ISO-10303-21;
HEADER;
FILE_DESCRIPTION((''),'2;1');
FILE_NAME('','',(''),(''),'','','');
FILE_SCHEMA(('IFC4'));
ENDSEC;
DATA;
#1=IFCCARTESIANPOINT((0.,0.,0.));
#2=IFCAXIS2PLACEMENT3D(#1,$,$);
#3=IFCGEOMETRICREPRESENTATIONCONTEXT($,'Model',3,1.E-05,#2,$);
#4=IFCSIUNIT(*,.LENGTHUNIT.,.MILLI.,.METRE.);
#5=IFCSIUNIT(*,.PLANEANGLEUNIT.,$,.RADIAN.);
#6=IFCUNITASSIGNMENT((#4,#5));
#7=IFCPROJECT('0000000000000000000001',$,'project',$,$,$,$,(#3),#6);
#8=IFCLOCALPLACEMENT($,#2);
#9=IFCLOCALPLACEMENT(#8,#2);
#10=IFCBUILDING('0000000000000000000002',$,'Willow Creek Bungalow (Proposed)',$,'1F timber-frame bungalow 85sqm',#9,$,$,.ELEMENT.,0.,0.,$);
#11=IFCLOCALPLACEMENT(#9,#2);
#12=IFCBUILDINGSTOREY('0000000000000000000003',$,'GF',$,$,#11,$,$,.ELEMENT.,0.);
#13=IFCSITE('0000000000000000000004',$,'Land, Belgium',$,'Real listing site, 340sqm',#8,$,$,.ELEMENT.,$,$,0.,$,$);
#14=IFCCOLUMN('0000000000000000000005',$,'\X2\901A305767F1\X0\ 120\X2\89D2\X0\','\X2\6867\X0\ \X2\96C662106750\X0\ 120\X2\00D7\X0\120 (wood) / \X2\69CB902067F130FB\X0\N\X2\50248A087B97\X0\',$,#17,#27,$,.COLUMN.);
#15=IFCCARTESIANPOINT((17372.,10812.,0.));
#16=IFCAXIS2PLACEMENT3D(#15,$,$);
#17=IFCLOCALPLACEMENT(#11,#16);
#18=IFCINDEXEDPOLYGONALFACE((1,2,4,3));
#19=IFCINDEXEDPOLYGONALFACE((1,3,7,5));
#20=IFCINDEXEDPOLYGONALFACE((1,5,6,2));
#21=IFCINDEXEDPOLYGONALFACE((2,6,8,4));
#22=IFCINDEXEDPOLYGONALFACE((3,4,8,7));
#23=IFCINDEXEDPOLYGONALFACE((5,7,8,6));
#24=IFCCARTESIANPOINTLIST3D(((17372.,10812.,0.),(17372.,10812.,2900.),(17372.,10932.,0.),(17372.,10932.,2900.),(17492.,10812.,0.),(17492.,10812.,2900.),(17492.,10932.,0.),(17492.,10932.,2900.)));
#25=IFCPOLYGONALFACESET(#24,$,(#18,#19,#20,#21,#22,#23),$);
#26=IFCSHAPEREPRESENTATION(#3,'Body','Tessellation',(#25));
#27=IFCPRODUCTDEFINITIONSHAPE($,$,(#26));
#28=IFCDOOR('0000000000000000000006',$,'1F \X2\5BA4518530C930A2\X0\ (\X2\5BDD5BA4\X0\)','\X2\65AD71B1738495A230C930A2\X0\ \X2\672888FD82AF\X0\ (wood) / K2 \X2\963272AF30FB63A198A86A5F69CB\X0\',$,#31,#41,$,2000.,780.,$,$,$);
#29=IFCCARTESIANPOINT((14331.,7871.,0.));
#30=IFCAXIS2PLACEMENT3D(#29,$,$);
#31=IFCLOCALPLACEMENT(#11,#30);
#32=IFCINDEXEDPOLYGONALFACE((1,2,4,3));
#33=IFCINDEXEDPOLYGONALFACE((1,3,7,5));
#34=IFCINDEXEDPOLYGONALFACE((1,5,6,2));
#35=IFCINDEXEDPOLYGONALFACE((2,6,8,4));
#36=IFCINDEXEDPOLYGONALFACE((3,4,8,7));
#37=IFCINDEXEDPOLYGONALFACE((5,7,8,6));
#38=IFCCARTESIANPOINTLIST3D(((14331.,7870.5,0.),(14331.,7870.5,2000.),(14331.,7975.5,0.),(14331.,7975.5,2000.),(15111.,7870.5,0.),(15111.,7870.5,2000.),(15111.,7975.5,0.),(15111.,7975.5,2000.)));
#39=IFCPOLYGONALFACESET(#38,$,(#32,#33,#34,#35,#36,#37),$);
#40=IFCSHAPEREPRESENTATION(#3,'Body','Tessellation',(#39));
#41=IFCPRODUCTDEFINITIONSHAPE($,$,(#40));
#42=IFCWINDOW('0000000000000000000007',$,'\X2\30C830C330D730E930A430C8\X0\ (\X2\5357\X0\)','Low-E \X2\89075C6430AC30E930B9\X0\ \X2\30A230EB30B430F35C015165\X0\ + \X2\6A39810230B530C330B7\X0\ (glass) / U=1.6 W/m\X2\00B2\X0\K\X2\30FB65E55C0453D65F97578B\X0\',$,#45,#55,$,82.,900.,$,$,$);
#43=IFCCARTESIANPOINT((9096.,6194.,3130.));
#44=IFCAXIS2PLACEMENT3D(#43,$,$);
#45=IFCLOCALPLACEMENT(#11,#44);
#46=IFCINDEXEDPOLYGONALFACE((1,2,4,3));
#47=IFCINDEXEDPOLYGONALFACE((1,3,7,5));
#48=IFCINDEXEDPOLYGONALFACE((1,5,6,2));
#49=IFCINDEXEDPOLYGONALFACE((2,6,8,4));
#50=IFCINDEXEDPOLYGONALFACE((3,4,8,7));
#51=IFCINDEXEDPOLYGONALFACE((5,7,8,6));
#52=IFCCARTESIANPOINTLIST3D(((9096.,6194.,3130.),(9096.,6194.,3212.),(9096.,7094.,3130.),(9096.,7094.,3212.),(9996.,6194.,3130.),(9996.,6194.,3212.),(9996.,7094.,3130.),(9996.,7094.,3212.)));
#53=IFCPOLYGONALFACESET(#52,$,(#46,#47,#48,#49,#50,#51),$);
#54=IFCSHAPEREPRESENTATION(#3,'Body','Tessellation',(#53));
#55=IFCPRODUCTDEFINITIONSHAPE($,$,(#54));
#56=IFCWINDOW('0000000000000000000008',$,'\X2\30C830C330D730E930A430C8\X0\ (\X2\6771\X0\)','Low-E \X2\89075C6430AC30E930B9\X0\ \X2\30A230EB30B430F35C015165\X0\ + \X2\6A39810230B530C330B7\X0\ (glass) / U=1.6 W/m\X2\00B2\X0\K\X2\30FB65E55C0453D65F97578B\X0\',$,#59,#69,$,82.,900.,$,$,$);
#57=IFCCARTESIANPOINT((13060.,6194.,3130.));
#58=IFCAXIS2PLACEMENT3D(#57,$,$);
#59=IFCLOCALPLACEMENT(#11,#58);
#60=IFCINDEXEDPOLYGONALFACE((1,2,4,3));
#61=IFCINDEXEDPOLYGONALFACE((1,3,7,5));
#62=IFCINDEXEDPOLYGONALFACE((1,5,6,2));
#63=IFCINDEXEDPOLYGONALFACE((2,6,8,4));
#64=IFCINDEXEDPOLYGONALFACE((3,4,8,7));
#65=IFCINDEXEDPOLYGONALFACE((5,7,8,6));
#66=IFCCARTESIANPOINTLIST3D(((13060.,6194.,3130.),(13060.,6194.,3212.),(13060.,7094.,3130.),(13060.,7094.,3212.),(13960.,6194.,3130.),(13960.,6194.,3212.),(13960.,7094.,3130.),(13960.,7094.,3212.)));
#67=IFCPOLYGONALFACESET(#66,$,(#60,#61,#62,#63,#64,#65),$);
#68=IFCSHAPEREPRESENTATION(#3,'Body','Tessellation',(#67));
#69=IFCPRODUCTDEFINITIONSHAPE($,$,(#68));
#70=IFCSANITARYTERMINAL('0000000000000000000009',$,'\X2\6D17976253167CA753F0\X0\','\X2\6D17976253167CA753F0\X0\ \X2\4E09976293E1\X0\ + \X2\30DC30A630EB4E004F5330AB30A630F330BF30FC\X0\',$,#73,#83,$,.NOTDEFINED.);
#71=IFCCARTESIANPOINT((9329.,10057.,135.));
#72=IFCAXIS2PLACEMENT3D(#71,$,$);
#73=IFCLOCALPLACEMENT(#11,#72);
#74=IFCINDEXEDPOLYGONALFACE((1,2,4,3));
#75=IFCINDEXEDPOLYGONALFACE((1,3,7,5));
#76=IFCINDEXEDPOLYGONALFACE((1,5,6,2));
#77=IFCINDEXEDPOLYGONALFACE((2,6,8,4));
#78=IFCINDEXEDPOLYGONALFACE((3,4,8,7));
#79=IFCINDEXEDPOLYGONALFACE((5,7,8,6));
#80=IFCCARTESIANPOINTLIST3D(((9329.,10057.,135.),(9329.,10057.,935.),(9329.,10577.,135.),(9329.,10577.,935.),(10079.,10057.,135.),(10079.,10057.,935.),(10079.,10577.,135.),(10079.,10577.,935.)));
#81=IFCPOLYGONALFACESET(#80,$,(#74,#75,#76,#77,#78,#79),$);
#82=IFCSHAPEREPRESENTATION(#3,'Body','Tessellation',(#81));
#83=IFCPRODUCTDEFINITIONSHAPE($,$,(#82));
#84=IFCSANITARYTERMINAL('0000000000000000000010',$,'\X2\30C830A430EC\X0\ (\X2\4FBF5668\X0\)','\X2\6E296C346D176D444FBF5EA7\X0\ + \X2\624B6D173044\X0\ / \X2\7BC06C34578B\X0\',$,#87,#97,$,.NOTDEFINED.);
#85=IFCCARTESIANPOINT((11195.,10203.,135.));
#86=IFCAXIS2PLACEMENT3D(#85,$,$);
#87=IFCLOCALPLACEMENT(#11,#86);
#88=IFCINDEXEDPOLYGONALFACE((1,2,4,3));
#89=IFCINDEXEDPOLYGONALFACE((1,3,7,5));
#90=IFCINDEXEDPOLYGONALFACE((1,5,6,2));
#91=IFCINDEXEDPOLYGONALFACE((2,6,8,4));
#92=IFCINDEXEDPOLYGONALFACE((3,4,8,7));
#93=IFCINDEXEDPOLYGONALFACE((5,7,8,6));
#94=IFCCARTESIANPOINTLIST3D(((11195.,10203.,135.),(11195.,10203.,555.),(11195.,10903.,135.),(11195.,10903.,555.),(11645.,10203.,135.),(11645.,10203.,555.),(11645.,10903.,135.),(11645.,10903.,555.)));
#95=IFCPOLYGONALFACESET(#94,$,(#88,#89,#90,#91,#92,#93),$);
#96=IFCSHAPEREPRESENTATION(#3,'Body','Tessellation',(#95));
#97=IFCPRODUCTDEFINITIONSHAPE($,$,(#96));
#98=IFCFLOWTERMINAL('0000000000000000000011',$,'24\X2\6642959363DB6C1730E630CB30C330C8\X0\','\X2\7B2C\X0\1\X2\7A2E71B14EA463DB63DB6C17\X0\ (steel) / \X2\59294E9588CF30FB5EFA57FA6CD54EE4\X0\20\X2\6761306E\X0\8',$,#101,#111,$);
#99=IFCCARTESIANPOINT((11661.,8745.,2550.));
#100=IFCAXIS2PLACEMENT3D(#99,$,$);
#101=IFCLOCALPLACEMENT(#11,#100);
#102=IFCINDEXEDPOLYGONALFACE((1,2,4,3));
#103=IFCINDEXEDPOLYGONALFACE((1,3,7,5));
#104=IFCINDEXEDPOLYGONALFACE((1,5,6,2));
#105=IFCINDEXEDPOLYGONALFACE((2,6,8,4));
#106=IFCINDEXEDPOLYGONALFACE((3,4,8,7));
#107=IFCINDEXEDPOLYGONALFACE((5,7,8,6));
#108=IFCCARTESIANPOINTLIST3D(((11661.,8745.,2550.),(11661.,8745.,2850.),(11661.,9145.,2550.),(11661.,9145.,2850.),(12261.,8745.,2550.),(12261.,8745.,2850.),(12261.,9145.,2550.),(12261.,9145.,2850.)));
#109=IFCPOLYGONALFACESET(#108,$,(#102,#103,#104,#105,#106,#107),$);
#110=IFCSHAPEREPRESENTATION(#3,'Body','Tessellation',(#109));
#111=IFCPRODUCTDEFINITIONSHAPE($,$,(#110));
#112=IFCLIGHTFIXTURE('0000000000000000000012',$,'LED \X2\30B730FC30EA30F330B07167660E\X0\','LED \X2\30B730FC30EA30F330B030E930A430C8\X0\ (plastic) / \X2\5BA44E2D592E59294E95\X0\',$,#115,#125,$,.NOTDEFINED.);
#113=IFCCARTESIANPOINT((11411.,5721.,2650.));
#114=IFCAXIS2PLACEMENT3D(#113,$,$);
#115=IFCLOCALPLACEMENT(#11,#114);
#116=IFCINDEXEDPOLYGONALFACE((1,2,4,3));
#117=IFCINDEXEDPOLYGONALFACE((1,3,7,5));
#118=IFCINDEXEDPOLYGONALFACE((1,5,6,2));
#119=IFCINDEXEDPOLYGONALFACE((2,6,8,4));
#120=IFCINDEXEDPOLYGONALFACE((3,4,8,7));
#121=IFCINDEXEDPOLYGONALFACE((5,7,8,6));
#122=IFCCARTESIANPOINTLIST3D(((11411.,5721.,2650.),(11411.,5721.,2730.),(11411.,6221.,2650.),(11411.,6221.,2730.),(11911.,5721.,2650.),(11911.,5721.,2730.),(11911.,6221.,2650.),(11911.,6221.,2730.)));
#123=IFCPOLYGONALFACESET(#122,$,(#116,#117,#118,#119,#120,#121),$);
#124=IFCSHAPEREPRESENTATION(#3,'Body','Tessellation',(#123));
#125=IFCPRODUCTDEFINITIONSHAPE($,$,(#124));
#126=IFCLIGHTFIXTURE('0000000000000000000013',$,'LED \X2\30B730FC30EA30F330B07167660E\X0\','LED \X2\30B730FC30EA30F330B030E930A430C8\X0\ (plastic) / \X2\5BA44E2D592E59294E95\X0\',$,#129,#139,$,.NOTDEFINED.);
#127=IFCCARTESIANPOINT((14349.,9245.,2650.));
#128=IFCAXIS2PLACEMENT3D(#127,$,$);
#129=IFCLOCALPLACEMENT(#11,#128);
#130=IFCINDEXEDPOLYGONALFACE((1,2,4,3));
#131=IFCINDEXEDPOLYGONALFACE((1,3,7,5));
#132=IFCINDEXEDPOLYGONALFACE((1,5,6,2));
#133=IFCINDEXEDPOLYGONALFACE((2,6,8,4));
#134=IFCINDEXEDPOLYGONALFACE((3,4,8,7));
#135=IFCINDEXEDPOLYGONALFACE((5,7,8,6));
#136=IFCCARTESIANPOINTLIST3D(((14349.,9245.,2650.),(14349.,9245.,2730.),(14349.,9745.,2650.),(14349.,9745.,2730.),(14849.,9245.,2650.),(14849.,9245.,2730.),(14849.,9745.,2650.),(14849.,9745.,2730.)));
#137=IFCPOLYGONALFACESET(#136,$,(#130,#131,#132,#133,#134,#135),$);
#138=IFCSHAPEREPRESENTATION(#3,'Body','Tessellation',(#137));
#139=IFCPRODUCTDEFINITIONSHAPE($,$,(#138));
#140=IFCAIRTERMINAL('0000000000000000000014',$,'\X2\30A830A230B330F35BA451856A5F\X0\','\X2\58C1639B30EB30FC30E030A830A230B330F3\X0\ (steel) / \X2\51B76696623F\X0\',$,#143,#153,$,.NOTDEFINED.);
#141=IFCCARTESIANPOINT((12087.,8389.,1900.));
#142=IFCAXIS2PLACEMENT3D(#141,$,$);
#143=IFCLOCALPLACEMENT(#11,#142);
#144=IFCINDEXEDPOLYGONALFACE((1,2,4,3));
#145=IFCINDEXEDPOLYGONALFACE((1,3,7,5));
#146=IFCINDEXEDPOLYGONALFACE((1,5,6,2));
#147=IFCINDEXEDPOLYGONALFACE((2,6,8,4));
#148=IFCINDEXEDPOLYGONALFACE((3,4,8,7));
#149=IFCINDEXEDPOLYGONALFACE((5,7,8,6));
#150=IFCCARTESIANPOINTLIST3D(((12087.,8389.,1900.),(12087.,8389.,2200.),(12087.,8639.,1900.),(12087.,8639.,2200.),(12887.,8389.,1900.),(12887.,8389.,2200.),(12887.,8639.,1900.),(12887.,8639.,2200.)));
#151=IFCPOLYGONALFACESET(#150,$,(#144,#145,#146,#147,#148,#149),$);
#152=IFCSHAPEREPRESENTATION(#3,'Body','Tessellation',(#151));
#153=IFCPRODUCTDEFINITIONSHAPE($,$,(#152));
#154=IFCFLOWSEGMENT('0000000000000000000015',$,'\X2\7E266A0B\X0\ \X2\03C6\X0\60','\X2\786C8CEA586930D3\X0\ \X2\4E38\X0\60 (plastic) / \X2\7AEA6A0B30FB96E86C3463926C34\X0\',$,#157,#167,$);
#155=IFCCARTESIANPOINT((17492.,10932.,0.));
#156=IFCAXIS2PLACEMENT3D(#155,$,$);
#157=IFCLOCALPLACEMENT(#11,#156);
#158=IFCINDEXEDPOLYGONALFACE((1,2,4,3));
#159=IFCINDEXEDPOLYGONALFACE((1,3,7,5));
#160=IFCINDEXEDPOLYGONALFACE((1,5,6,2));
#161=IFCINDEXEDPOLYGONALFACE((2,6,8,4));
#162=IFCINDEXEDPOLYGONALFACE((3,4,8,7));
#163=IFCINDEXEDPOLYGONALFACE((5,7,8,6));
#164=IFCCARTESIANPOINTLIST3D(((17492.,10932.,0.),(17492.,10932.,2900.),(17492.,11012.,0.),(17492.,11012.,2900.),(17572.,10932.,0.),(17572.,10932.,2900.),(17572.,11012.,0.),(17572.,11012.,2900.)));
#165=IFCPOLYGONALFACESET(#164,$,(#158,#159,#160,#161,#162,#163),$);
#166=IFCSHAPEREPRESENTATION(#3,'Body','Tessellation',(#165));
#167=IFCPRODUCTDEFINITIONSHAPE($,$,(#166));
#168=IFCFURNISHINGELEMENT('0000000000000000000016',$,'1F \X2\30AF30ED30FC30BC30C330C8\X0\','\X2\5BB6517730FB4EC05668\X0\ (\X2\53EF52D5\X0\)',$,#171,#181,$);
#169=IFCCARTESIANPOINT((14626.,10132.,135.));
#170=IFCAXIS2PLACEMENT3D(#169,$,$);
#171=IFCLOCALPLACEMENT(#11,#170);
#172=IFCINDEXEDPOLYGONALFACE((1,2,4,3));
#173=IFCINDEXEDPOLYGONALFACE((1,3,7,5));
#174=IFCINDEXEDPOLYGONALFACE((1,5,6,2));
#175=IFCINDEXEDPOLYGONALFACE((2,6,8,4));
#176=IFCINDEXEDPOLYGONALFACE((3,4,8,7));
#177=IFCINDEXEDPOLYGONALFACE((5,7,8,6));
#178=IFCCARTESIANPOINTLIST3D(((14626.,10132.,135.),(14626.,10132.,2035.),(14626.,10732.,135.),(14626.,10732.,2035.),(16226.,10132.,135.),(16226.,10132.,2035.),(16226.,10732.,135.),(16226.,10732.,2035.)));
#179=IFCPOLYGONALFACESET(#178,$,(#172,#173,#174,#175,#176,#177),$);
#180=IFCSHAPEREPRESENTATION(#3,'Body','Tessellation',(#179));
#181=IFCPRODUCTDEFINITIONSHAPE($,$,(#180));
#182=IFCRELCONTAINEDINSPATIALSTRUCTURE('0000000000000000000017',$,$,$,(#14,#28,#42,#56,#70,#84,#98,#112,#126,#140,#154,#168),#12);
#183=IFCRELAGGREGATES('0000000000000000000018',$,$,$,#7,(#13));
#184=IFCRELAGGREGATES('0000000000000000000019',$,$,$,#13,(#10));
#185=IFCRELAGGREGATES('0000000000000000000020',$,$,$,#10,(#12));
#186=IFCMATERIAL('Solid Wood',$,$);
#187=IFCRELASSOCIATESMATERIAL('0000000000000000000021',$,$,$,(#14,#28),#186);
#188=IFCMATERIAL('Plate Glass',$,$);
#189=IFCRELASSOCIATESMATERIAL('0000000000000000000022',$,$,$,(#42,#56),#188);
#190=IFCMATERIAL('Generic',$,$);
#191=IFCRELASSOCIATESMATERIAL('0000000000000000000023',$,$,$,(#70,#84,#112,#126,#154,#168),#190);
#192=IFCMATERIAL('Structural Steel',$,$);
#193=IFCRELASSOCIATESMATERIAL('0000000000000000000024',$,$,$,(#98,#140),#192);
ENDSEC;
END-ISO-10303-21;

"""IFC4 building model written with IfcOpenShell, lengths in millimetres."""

from ifc_helpers import new_model, si_unit, frame, frame_2d, origin, place, context, project, spatial, rectangle, extrude, material, element, save


model = new_model("IFC4")

# Units and contexts
model_context = context("Model", 3, precision=1e-05, world=origin())
ifc_project = project(units=[si_unit("LENGTHUNIT", "METRE", prefix="MILLI"), si_unit("PLANEANGLEUNIT", "RADIAN")], contexts=[model_context])

# Site, building, storey
site_placement = place(None, origin())
site = spatial("IfcSite", under=ifc_project, at=site_placement, Name="Land, Belgium", ObjectType="Real listing site, 340sqm", CompositionType="ELEMENT", RefElevation=0.0)
building_placement = place(site_placement, origin())
building = spatial("IfcBuilding", under=site, at=building_placement, Name="Willow Creek Bungalow (Proposed)", ObjectType="1F timber-frame bungalow 85sqm", CompositionType="ELEMENT", ElevationOfRefHeight=0.0, ElevationOfTerrain=0.0)
storey_placement = place(building_placement, origin())
storey = spatial("IfcBuildingStorey", under=building, at=storey_placement, Name="GF", CompositionType="ELEMENT", Elevation=0.0)

# Column
ifc_material_1 = material(Name="Solid Wood")
column_1_placement = place(storey_placement, frame((17372.0, 10812.0, 0.0)))
element("IfcColumn", 1, at=column_1_placement, inside=storey, material=ifc_material_1, Name="通し柱 120角", Description="桧 集成材 120×120 (wood) / 構造柱・N値計算", PredefinedType="COLUMN", context=model_context, shape_type="SweptSolid", body=[
    extrude(rectangle(XDim=120.0, YDim=120.0, at=frame_2d((60.0, 60.0))), frame((17372.0, 10812.0, 0.0)), (0.0, 0.0, 1.0), 2900.0),
])

# Door
door_placement = place(storey_placement, frame((14331.0, 7871.0, 0.0)))
element("IfcDoor", 2, at=door_placement, inside=storey, material=ifc_material_1, Name="1F 室内ドア (寝室)", Description="断熱玄関ドア 木製芯 (wood) / K2 防犯・採風機構", OverallHeight=2000.0, OverallWidth=780.0, context=model_context, shape_type="SweptSolid", body=[
    extrude(rectangle(XDim=780.0, YDim=105.0, at=frame_2d((390.0, 52.0))), frame((14331.0, 7871.0, 0.0)), (0.0, 0.0, 1.0), 2000.0),
])

# Windows
ifc_material_2 = material(Name="Plate Glass")
window_1_placement = place(storey_placement, frame((9096.0, 6194.0, 3130.0)))
element("IfcWindow", 3, at=window_1_placement, inside=storey, material=ifc_material_2, Name="トップライト (南)", Description="Low-E 複層ガラス アルゴン封入 + 樹脂サッシ (glass) / U=1.6 W/m²K・日射取得型", OverallHeight=82.0, OverallWidth=900.0, context=model_context, shape_type="SweptSolid", body=[
    extrude(rectangle(XDim=900.0, YDim=900.0, at=frame_2d((450.0, 450.0))), frame((9096.0, 6194.0, 3130.0)), (0.0, 0.0, 1.0), 82.0),
])
window_2_placement = place(storey_placement, frame((13060.0, 6194.0, 3130.0)))
element("IfcWindow", 4, at=window_2_placement, inside=storey, material=ifc_material_2, Name="トップライト (東)", Description="Low-E 複層ガラス アルゴン封入 + 樹脂サッシ (glass) / U=1.6 W/m²K・日射取得型", OverallHeight=82.0, OverallWidth=900.0, context=model_context, shape_type="SweptSolid", body=[
    extrude(rectangle(XDim=900.0, YDim=900.0, at=frame_2d((450.0, 450.0))), frame((13060.0, 6194.0, 3130.0)), (0.0, 0.0, 1.0), 82.0),
])

# Sanitary terminals
ifc_material_3 = material(Name="Generic")
sanitary_terminal_1_placement = place(storey_placement, frame((9329.0, 10057.0, 135.0)))
element("IfcSanitaryTerminal", 5, at=sanitary_terminal_1_placement, inside=storey, material=ifc_material_3, Name="洗面化粧台", Description="洗面化粧台 三面鏡 + ボウル一体カウンター", PredefinedType="NOTDEFINED", context=model_context, shape_type="SweptSolid", body=[
    extrude(rectangle(XDim=750.0, YDim=520.0, at=frame_2d((375.0, 260.0))), frame((9329.0, 10057.0, 135.0)), (0.0, 0.0, 1.0), 800.0),
])
sanitary_terminal_2_placement = place(storey_placement, frame((11195.0, 10203.0, 135.0)))
element("IfcSanitaryTerminal", 6, at=sanitary_terminal_2_placement, inside=storey, material=ifc_material_3, Name="トイレ (便器)", Description="温水洗浄便座 + 手洗い / 節水型", PredefinedType="NOTDEFINED", context=model_context, shape_type="SweptSolid", body=[
    extrude(rectangle(XDim=450.0, YDim=700.0, at=frame_2d((225.0, 350.0))), frame((11195.0, 10203.0, 135.0)), (0.0, 0.0, 1.0), 420.0),
])

# Flow terminal
ifc_material_4 = material(Name="Structural Steel")
flow_terminal_placement = place(storey_placement, frame((11661.0, 8745.0, 2550.0)))
element("IfcFlowTerminal", 7, at=flow_terminal_placement, inside=storey, material=ifc_material_4, Name="24時間換気ユニット", Description="第1種熱交換換気 (steel) / 天井裏・建基法令20条の8", context=model_context, shape_type="SweptSolid", body=[
    extrude(rectangle(XDim=600.0, YDim=400.0, at=frame_2d((300.0, 200.0))), frame((11661.0, 8745.0, 2550.0)), (0.0, 0.0, 1.0), 300.0),
])

# Light fixtures
light_fixture_1_placement = place(storey_placement, frame((11411.0, 5721.0, 2650.0)))
element("IfcLightFixture", 8, at=light_fixture_1_placement, inside=storey, material=ifc_material_3, Name="LED シーリング照明", Description="LED シーリングライト (plastic) / 室中央天井", PredefinedType="NOTDEFINED", context=model_context, shape_type="SweptSolid", body=[
    extrude(rectangle(XDim=500.0, YDim=500.0, at=frame_2d((250.0, 250.0))), frame((11411.0, 5721.0, 2650.0)), (0.0, 0.0, 1.0), 80.0),
])
light_fixture_2_placement = place(storey_placement, frame((14349.0, 9245.0, 2650.0)))
element("IfcLightFixture", 9, at=light_fixture_2_placement, inside=storey, material=ifc_material_3, Name="LED シーリング照明", Description="LED シーリングライト (plastic) / 室中央天井", PredefinedType="NOTDEFINED", context=model_context, shape_type="SweptSolid", body=[
    extrude(rectangle(XDim=500.0, YDim=500.0, at=frame_2d((250.0, 250.0))), frame((14349.0, 9245.0, 2650.0)), (0.0, 0.0, 1.0), 80.0),
])

# Air terminal
air_terminal_placement = place(storey_placement, frame((12087.0, 8389.0, 1900.0)))
element("IfcAirTerminal", 10, at=air_terminal_placement, inside=storey, material=ifc_material_4, Name="エアコン室内機", Description="壁掛ルームエアコン (steel) / 冷暖房", PredefinedType="NOTDEFINED", context=model_context, shape_type="SweptSolid", body=[
    extrude(rectangle(XDim=800.0, YDim=250.0, at=frame_2d((400.0, 125.0))), frame((12087.0, 8389.0, 1900.0)), (0.0, 0.0, 1.0), 300.0),
])

# Flow segment
flow_segment_placement = place(storey_placement, frame((17492.0, 10932.0, 0.0)))
element("IfcFlowSegment", 11, at=flow_segment_placement, inside=storey, material=ifc_material_3, Name="縦樋 φ60", Description="硬質塩ビ 丸60 (plastic) / 竪樋・雨水排水", context=model_context, shape_type="SweptSolid", body=[
    extrude(rectangle(XDim=80.0, YDim=80.0, at=frame_2d((40.0, 40.0))), frame((17492.0, 10932.0, 0.0)), (0.0, 0.0, 1.0), 2900.0),
])

# Furnishing element
furnishing_placement = place(storey_placement, frame((14626.0, 10132.0, 135.0)))
element("IfcFurnishingElement", 12, at=furnishing_placement, inside=storey, material=ifc_material_3, Name="1F クローゼット", Description="家具・什器 (可動)", context=model_context, shape_type="SweptSolid", body=[
    extrude(rectangle(XDim=1600.0, YDim=600.0, at=frame_2d((800.0, 300.0))), frame((14626.0, 10132.0, 135.0)), (0.0, 0.0, 1.0), 1900.0),
])

save(model, "model.ifc")
